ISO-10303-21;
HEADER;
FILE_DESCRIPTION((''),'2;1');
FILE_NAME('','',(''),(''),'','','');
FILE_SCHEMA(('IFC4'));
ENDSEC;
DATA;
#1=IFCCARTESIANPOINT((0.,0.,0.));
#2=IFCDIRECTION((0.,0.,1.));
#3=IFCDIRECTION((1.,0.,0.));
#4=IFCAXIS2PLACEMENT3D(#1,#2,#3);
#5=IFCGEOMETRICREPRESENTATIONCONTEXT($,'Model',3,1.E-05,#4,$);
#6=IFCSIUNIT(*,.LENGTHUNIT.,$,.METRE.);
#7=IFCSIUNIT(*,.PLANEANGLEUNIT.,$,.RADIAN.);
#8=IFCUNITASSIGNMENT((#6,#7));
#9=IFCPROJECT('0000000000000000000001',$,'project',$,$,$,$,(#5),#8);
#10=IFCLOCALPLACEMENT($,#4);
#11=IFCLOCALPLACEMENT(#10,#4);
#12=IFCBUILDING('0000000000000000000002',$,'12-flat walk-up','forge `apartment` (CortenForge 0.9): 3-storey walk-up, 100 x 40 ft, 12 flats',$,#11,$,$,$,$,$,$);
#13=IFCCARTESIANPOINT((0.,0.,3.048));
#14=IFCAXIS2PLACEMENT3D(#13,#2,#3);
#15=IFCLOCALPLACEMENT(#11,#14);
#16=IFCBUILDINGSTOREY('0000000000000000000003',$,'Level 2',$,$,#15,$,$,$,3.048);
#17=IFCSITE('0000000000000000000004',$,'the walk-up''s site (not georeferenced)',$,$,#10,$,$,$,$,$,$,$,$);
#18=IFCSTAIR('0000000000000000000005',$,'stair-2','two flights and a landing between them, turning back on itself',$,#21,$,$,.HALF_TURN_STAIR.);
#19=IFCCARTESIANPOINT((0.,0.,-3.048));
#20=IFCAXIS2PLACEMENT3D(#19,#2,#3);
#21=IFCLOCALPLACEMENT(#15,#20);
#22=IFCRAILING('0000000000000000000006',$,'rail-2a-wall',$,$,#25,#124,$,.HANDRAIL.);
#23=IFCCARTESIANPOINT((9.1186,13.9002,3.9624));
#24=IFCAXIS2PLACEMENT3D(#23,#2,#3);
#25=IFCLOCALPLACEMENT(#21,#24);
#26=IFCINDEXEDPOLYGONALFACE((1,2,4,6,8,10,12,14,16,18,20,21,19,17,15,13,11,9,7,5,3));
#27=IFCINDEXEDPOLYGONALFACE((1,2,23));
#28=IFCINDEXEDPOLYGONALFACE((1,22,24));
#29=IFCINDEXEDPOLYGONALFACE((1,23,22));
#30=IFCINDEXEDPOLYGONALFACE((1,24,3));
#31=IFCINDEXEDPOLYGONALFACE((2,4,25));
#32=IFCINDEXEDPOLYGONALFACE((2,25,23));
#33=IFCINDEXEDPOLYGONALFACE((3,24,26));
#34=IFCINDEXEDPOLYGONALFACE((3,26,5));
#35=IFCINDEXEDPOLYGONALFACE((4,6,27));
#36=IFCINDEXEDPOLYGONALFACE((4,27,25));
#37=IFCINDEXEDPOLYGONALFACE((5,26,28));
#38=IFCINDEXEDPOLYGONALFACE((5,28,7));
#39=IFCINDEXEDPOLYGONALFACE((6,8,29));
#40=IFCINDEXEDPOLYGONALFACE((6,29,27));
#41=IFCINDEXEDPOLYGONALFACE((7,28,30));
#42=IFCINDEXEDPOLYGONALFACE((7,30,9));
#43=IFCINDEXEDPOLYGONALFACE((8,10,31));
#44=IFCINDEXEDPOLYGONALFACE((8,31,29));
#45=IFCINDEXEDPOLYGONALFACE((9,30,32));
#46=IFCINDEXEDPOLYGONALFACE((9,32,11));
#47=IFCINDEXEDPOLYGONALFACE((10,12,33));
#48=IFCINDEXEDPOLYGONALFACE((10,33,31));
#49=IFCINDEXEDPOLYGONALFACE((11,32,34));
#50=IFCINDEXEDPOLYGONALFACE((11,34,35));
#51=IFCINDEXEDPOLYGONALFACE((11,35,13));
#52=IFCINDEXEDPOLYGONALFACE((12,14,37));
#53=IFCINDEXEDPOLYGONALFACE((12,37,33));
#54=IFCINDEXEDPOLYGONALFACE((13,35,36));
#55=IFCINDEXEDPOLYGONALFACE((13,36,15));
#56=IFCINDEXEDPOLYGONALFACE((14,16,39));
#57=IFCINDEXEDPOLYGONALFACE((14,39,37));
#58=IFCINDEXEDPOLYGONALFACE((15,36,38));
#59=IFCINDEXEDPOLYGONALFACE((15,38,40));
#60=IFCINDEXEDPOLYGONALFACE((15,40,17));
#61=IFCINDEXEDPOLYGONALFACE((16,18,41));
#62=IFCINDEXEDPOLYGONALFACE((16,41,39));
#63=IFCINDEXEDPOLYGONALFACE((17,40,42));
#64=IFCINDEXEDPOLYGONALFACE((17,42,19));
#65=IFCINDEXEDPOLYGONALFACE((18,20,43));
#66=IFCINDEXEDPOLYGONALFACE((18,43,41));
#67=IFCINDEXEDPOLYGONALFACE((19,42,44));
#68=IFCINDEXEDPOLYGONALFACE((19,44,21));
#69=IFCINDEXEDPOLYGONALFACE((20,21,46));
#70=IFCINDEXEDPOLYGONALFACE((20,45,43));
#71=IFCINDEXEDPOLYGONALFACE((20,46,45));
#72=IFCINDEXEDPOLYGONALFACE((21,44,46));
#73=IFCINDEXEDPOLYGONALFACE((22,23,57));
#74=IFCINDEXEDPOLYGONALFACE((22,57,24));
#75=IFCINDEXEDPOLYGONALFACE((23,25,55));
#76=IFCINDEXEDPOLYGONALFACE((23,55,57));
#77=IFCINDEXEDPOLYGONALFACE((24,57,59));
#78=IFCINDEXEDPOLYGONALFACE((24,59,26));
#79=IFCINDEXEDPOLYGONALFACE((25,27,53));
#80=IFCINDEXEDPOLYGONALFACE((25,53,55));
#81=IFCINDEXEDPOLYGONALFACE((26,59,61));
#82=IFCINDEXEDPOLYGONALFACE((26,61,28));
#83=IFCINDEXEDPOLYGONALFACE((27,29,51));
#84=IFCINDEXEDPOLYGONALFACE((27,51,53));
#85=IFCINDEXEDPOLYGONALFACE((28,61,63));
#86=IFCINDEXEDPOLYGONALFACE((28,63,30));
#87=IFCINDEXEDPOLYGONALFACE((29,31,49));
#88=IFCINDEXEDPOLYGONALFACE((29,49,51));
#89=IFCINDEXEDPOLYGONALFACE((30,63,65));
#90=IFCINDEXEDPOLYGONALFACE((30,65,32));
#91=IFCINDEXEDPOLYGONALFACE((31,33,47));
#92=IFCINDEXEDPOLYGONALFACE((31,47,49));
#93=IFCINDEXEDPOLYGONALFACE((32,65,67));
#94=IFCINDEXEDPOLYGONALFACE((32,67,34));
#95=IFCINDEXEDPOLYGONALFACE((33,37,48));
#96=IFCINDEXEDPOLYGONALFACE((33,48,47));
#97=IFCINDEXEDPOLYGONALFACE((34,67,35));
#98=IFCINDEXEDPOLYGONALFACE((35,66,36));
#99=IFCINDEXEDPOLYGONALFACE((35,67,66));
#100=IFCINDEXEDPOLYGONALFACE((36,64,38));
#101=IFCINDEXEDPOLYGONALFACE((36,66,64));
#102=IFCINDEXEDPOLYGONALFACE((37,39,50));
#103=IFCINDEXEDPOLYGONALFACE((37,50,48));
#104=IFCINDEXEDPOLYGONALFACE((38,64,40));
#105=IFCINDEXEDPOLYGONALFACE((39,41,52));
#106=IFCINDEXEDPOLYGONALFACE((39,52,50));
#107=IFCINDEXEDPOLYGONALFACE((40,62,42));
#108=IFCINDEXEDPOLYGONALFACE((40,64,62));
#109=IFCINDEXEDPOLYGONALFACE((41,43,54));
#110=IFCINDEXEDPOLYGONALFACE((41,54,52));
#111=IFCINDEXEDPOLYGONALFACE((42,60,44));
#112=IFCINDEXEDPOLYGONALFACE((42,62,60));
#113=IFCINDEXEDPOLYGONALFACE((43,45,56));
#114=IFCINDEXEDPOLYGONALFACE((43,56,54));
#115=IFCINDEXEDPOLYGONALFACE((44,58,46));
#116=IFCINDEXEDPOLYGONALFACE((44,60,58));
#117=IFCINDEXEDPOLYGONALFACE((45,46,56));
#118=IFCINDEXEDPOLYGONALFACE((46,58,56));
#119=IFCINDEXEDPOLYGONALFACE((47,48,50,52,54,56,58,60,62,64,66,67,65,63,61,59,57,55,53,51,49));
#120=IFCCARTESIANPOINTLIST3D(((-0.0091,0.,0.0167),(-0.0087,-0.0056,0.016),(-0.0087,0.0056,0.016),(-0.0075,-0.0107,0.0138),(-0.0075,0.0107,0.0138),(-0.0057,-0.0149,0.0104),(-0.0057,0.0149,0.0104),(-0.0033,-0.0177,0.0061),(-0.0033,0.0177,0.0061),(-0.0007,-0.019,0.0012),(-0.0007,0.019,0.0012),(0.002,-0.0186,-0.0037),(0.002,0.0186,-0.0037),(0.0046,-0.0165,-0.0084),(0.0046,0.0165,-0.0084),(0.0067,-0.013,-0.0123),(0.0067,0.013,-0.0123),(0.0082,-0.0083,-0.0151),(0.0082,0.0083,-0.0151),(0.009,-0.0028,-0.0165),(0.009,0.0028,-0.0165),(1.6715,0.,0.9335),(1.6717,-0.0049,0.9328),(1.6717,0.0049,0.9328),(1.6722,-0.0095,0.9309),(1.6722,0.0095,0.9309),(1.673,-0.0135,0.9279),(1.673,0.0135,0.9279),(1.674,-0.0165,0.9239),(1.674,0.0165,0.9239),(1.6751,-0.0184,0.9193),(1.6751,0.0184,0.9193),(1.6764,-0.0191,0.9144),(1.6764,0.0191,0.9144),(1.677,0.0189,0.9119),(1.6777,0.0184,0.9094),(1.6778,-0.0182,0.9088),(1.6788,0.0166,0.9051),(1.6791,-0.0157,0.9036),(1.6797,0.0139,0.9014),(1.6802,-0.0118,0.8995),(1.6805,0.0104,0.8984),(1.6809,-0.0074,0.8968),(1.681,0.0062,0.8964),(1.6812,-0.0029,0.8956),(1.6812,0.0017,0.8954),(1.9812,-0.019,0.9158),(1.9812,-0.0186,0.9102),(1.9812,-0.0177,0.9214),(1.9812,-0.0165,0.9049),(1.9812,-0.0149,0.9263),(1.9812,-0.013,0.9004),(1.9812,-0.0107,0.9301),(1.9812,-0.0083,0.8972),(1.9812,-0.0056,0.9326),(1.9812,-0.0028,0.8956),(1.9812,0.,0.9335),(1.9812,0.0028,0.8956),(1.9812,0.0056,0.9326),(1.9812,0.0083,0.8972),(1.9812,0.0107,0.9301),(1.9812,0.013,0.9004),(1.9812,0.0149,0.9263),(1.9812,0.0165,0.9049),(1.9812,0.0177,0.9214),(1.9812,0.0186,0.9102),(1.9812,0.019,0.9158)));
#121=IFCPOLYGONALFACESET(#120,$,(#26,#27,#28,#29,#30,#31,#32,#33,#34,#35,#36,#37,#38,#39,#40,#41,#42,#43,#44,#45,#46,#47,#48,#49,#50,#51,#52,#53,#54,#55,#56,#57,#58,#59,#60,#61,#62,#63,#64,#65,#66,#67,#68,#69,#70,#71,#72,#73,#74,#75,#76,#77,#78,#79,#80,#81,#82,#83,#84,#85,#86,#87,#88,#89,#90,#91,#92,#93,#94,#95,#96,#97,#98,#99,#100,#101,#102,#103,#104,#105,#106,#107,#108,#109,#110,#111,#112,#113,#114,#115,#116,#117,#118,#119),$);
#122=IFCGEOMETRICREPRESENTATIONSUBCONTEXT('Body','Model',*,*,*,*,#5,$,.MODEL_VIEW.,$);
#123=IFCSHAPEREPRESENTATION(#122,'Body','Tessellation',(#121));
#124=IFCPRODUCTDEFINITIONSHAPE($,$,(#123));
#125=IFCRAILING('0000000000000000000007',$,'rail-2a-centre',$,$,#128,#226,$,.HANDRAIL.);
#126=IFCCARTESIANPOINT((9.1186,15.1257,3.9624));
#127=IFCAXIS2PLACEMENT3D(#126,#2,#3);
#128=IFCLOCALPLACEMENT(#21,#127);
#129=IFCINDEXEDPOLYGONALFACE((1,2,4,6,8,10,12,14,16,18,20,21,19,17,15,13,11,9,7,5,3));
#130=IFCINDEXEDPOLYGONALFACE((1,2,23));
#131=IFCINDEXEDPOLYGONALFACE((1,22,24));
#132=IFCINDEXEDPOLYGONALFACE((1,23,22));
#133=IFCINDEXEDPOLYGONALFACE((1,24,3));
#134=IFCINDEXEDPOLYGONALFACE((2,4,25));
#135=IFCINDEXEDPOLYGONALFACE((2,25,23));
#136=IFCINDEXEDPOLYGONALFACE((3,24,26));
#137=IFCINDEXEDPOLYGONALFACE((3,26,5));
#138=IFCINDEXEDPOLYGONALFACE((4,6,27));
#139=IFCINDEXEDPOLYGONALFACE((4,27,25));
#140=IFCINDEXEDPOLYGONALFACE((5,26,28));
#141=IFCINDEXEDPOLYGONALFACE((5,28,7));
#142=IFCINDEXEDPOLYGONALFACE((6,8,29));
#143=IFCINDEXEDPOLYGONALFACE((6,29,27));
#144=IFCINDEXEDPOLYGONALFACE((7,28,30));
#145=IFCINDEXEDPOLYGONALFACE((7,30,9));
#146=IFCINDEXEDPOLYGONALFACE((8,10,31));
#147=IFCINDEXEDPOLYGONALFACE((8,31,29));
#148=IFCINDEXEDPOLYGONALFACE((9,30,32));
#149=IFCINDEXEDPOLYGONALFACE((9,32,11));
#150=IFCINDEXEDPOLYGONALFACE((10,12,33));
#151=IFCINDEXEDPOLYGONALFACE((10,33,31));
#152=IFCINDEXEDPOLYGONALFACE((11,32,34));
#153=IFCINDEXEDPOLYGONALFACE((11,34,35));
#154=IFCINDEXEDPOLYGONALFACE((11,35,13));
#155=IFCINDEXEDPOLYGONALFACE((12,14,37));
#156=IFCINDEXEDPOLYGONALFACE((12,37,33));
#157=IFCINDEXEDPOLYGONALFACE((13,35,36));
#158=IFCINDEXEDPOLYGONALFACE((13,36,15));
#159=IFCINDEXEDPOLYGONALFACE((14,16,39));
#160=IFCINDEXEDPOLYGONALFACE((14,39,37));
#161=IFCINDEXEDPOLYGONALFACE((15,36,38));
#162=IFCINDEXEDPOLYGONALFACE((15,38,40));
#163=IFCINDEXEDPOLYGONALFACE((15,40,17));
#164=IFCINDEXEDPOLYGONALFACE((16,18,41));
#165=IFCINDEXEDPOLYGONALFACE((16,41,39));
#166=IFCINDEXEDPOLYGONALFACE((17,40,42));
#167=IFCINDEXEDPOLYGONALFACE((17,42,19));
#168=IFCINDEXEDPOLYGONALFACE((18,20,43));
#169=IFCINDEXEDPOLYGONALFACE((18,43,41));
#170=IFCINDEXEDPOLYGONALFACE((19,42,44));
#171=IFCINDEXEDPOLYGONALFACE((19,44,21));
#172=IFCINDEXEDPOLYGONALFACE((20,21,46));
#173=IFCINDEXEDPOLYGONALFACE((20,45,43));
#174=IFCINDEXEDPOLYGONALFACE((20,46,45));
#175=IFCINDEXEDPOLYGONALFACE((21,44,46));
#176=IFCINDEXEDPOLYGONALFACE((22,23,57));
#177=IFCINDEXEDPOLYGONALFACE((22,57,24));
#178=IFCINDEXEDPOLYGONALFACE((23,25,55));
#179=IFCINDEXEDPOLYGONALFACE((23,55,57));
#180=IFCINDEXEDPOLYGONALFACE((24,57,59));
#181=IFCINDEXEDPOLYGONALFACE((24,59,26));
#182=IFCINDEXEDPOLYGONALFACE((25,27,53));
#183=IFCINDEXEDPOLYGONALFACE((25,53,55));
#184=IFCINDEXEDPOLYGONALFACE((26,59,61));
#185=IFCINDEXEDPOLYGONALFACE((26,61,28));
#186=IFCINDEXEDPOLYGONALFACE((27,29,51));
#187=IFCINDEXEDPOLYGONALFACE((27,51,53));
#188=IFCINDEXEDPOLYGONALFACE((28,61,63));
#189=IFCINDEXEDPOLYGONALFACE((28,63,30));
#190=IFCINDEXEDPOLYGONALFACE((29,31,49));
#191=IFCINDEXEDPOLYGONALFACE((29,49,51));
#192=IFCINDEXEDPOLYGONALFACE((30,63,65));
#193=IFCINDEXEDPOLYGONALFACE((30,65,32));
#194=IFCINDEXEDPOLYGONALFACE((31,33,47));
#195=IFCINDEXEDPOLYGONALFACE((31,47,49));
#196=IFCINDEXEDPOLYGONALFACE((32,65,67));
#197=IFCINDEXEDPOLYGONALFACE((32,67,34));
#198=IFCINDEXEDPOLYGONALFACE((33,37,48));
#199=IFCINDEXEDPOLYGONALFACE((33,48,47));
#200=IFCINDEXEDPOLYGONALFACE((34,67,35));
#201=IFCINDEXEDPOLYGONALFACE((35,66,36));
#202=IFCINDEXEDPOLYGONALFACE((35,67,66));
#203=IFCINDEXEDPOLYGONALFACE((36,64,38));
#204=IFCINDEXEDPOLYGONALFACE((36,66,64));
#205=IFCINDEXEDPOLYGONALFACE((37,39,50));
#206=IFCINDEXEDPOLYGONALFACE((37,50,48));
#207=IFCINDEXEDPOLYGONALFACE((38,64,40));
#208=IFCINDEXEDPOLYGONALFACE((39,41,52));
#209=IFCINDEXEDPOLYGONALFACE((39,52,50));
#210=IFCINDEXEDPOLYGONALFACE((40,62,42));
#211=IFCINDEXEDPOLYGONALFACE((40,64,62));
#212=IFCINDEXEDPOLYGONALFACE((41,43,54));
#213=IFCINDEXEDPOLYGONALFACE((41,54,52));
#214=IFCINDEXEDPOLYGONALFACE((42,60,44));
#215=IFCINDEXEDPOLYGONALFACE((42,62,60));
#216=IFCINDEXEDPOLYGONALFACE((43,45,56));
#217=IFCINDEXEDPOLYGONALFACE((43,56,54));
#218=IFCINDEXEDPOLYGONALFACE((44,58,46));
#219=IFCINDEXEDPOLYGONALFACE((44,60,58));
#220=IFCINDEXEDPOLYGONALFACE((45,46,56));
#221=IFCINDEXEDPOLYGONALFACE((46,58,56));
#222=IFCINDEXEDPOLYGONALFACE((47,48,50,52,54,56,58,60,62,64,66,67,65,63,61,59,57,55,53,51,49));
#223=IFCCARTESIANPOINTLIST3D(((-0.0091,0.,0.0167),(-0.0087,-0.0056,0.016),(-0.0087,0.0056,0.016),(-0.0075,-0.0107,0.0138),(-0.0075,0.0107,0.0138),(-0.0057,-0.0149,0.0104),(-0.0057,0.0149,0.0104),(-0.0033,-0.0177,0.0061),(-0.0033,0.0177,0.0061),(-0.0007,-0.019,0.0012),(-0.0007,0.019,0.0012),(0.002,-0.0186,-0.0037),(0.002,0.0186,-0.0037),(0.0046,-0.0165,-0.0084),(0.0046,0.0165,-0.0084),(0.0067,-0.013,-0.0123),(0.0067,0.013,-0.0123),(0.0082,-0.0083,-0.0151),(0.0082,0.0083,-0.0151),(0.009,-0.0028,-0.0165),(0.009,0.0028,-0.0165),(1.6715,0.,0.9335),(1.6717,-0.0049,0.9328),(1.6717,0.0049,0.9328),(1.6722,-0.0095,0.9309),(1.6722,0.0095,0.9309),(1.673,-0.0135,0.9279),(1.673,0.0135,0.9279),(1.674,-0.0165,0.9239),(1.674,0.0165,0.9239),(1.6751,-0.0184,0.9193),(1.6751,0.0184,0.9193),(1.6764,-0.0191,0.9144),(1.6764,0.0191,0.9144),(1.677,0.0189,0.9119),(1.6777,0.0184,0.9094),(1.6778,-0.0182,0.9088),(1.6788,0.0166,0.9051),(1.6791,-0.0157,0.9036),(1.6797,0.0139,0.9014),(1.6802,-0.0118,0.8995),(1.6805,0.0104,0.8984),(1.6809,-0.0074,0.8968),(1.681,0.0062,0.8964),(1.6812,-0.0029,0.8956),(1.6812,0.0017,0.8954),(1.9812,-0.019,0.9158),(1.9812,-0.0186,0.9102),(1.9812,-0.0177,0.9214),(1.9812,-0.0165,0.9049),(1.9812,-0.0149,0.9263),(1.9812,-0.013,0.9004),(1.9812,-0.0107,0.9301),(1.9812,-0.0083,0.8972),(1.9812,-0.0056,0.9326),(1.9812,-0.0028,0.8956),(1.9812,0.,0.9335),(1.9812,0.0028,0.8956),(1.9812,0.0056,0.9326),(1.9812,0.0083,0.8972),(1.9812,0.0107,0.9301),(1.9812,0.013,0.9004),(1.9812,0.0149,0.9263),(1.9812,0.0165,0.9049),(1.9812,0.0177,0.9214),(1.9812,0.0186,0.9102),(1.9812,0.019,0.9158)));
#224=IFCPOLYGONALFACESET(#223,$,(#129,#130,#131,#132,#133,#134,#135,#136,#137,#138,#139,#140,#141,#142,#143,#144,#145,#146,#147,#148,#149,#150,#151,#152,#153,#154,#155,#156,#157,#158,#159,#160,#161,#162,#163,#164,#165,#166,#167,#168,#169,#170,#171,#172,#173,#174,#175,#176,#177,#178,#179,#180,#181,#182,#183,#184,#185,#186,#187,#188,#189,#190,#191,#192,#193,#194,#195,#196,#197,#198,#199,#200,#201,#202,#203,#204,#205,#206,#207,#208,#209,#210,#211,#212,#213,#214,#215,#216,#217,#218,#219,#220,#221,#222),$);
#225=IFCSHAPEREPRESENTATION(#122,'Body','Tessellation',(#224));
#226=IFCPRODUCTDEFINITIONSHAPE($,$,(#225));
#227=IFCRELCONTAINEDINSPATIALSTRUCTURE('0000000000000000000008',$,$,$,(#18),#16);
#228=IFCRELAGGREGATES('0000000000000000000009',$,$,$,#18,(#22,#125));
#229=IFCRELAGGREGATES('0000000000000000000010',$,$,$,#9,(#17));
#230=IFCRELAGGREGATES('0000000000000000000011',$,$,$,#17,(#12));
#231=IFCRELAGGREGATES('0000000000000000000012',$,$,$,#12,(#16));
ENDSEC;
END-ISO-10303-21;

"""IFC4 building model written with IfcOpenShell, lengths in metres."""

from ifc_helpers import new_model, entity, si_unit, frame, origin_with_axes, place, context, subcontext, project, spatial, element, aggregate, save


model = new_model("IFC4")

# Units and contexts
model_context = context("Model", 3, precision=1e-05, world=origin_with_axes())
body_context = subcontext(model_context, "Body", "Model", "MODEL_VIEW")
ifc_project = project(units=[si_unit("LENGTHUNIT", "METRE"), si_unit("PLANEANGLEUNIT", "RADIAN")], contexts=[model_context])

# Site, building, storey
site_placement = place(None, origin_with_axes())
site = spatial("IfcSite", under=ifc_project, at=site_placement, Name="the walk-up's site (not georeferenced)")
building_placement = place(site_placement, origin_with_axes())
building = spatial("IfcBuilding", under=site, at=building_placement, Name="12-flat walk-up", Description="forge `apartment` (CortenForge 0.9): 3-storey walk-up, 100 x 40 ft, 12 flats")
storey_placement = place(building_placement, frame((0.0, 0.0, 3.048), z_axis=(0.0, 0.0, 1.0), x_axis=(1.0, 0.0, 0.0)))
storey = spatial("IfcBuildingStorey", under=building, at=storey_placement, Name="Level 2", Elevation=3.048)

# Stair, railings
stair_placement = place(storey_placement, frame((0.0, 0.0, -3.048), z_axis=(0.0, 0.0, 1.0), x_axis=(1.0, 0.0, 0.0)))
stair = element("IfcStair", 1, at=stair_placement, inside=storey, Name="stair-2", Description="two flights and a landing between them, turning back on itself", PredefinedType="HALF_TURN_STAIR")
railing_1_placement = place(stair_placement, frame((9.1186, 13.9002, 3.9624), z_axis=(0.0, 0.0, 1.0), x_axis=(1.0, 0.0, 0.0)))
railing_1 = element("IfcRailing", 2, at=railing_1_placement, Name="rail-2a-wall", PredefinedType="HANDRAIL", context=body_context, shape_type="AdvancedSweptSolid", body=[
    entity("IfcSweptDiskSolid", entity("IfcPolyline", [entity("IfcCartesianPoint", [0.0, 0.0, 0.0]), entity("IfcCartesianPoint", [1.6764, 0.0, 0.9144]), entity("IfcCartesianPoint", [1.9812, 0.0, 0.9144])]), 0.0191),
])
railing_2_placement = place(stair_placement, frame((9.1186, 15.1257, 3.9624), z_axis=(0.0, 0.0, 1.0), x_axis=(1.0, 0.0, 0.0)))
railing_2 = element("IfcRailing", 3, at=railing_2_placement, Name="rail-2a-centre", PredefinedType="HANDRAIL", context=body_context, shape_type="AdvancedSweptSolid", body=[
    entity("IfcSweptDiskSolid", entity("IfcPolyline", [entity("IfcCartesianPoint", [0.0, 0.0, 0.0]), entity("IfcCartesianPoint", [1.6764, 0.0, 0.9144]), entity("IfcCartesianPoint", [1.9812, 0.0, 0.9144])]), 0.0191),
])
aggregate(stair, [railing_1, railing_2])

save(model, "model.ifc")
